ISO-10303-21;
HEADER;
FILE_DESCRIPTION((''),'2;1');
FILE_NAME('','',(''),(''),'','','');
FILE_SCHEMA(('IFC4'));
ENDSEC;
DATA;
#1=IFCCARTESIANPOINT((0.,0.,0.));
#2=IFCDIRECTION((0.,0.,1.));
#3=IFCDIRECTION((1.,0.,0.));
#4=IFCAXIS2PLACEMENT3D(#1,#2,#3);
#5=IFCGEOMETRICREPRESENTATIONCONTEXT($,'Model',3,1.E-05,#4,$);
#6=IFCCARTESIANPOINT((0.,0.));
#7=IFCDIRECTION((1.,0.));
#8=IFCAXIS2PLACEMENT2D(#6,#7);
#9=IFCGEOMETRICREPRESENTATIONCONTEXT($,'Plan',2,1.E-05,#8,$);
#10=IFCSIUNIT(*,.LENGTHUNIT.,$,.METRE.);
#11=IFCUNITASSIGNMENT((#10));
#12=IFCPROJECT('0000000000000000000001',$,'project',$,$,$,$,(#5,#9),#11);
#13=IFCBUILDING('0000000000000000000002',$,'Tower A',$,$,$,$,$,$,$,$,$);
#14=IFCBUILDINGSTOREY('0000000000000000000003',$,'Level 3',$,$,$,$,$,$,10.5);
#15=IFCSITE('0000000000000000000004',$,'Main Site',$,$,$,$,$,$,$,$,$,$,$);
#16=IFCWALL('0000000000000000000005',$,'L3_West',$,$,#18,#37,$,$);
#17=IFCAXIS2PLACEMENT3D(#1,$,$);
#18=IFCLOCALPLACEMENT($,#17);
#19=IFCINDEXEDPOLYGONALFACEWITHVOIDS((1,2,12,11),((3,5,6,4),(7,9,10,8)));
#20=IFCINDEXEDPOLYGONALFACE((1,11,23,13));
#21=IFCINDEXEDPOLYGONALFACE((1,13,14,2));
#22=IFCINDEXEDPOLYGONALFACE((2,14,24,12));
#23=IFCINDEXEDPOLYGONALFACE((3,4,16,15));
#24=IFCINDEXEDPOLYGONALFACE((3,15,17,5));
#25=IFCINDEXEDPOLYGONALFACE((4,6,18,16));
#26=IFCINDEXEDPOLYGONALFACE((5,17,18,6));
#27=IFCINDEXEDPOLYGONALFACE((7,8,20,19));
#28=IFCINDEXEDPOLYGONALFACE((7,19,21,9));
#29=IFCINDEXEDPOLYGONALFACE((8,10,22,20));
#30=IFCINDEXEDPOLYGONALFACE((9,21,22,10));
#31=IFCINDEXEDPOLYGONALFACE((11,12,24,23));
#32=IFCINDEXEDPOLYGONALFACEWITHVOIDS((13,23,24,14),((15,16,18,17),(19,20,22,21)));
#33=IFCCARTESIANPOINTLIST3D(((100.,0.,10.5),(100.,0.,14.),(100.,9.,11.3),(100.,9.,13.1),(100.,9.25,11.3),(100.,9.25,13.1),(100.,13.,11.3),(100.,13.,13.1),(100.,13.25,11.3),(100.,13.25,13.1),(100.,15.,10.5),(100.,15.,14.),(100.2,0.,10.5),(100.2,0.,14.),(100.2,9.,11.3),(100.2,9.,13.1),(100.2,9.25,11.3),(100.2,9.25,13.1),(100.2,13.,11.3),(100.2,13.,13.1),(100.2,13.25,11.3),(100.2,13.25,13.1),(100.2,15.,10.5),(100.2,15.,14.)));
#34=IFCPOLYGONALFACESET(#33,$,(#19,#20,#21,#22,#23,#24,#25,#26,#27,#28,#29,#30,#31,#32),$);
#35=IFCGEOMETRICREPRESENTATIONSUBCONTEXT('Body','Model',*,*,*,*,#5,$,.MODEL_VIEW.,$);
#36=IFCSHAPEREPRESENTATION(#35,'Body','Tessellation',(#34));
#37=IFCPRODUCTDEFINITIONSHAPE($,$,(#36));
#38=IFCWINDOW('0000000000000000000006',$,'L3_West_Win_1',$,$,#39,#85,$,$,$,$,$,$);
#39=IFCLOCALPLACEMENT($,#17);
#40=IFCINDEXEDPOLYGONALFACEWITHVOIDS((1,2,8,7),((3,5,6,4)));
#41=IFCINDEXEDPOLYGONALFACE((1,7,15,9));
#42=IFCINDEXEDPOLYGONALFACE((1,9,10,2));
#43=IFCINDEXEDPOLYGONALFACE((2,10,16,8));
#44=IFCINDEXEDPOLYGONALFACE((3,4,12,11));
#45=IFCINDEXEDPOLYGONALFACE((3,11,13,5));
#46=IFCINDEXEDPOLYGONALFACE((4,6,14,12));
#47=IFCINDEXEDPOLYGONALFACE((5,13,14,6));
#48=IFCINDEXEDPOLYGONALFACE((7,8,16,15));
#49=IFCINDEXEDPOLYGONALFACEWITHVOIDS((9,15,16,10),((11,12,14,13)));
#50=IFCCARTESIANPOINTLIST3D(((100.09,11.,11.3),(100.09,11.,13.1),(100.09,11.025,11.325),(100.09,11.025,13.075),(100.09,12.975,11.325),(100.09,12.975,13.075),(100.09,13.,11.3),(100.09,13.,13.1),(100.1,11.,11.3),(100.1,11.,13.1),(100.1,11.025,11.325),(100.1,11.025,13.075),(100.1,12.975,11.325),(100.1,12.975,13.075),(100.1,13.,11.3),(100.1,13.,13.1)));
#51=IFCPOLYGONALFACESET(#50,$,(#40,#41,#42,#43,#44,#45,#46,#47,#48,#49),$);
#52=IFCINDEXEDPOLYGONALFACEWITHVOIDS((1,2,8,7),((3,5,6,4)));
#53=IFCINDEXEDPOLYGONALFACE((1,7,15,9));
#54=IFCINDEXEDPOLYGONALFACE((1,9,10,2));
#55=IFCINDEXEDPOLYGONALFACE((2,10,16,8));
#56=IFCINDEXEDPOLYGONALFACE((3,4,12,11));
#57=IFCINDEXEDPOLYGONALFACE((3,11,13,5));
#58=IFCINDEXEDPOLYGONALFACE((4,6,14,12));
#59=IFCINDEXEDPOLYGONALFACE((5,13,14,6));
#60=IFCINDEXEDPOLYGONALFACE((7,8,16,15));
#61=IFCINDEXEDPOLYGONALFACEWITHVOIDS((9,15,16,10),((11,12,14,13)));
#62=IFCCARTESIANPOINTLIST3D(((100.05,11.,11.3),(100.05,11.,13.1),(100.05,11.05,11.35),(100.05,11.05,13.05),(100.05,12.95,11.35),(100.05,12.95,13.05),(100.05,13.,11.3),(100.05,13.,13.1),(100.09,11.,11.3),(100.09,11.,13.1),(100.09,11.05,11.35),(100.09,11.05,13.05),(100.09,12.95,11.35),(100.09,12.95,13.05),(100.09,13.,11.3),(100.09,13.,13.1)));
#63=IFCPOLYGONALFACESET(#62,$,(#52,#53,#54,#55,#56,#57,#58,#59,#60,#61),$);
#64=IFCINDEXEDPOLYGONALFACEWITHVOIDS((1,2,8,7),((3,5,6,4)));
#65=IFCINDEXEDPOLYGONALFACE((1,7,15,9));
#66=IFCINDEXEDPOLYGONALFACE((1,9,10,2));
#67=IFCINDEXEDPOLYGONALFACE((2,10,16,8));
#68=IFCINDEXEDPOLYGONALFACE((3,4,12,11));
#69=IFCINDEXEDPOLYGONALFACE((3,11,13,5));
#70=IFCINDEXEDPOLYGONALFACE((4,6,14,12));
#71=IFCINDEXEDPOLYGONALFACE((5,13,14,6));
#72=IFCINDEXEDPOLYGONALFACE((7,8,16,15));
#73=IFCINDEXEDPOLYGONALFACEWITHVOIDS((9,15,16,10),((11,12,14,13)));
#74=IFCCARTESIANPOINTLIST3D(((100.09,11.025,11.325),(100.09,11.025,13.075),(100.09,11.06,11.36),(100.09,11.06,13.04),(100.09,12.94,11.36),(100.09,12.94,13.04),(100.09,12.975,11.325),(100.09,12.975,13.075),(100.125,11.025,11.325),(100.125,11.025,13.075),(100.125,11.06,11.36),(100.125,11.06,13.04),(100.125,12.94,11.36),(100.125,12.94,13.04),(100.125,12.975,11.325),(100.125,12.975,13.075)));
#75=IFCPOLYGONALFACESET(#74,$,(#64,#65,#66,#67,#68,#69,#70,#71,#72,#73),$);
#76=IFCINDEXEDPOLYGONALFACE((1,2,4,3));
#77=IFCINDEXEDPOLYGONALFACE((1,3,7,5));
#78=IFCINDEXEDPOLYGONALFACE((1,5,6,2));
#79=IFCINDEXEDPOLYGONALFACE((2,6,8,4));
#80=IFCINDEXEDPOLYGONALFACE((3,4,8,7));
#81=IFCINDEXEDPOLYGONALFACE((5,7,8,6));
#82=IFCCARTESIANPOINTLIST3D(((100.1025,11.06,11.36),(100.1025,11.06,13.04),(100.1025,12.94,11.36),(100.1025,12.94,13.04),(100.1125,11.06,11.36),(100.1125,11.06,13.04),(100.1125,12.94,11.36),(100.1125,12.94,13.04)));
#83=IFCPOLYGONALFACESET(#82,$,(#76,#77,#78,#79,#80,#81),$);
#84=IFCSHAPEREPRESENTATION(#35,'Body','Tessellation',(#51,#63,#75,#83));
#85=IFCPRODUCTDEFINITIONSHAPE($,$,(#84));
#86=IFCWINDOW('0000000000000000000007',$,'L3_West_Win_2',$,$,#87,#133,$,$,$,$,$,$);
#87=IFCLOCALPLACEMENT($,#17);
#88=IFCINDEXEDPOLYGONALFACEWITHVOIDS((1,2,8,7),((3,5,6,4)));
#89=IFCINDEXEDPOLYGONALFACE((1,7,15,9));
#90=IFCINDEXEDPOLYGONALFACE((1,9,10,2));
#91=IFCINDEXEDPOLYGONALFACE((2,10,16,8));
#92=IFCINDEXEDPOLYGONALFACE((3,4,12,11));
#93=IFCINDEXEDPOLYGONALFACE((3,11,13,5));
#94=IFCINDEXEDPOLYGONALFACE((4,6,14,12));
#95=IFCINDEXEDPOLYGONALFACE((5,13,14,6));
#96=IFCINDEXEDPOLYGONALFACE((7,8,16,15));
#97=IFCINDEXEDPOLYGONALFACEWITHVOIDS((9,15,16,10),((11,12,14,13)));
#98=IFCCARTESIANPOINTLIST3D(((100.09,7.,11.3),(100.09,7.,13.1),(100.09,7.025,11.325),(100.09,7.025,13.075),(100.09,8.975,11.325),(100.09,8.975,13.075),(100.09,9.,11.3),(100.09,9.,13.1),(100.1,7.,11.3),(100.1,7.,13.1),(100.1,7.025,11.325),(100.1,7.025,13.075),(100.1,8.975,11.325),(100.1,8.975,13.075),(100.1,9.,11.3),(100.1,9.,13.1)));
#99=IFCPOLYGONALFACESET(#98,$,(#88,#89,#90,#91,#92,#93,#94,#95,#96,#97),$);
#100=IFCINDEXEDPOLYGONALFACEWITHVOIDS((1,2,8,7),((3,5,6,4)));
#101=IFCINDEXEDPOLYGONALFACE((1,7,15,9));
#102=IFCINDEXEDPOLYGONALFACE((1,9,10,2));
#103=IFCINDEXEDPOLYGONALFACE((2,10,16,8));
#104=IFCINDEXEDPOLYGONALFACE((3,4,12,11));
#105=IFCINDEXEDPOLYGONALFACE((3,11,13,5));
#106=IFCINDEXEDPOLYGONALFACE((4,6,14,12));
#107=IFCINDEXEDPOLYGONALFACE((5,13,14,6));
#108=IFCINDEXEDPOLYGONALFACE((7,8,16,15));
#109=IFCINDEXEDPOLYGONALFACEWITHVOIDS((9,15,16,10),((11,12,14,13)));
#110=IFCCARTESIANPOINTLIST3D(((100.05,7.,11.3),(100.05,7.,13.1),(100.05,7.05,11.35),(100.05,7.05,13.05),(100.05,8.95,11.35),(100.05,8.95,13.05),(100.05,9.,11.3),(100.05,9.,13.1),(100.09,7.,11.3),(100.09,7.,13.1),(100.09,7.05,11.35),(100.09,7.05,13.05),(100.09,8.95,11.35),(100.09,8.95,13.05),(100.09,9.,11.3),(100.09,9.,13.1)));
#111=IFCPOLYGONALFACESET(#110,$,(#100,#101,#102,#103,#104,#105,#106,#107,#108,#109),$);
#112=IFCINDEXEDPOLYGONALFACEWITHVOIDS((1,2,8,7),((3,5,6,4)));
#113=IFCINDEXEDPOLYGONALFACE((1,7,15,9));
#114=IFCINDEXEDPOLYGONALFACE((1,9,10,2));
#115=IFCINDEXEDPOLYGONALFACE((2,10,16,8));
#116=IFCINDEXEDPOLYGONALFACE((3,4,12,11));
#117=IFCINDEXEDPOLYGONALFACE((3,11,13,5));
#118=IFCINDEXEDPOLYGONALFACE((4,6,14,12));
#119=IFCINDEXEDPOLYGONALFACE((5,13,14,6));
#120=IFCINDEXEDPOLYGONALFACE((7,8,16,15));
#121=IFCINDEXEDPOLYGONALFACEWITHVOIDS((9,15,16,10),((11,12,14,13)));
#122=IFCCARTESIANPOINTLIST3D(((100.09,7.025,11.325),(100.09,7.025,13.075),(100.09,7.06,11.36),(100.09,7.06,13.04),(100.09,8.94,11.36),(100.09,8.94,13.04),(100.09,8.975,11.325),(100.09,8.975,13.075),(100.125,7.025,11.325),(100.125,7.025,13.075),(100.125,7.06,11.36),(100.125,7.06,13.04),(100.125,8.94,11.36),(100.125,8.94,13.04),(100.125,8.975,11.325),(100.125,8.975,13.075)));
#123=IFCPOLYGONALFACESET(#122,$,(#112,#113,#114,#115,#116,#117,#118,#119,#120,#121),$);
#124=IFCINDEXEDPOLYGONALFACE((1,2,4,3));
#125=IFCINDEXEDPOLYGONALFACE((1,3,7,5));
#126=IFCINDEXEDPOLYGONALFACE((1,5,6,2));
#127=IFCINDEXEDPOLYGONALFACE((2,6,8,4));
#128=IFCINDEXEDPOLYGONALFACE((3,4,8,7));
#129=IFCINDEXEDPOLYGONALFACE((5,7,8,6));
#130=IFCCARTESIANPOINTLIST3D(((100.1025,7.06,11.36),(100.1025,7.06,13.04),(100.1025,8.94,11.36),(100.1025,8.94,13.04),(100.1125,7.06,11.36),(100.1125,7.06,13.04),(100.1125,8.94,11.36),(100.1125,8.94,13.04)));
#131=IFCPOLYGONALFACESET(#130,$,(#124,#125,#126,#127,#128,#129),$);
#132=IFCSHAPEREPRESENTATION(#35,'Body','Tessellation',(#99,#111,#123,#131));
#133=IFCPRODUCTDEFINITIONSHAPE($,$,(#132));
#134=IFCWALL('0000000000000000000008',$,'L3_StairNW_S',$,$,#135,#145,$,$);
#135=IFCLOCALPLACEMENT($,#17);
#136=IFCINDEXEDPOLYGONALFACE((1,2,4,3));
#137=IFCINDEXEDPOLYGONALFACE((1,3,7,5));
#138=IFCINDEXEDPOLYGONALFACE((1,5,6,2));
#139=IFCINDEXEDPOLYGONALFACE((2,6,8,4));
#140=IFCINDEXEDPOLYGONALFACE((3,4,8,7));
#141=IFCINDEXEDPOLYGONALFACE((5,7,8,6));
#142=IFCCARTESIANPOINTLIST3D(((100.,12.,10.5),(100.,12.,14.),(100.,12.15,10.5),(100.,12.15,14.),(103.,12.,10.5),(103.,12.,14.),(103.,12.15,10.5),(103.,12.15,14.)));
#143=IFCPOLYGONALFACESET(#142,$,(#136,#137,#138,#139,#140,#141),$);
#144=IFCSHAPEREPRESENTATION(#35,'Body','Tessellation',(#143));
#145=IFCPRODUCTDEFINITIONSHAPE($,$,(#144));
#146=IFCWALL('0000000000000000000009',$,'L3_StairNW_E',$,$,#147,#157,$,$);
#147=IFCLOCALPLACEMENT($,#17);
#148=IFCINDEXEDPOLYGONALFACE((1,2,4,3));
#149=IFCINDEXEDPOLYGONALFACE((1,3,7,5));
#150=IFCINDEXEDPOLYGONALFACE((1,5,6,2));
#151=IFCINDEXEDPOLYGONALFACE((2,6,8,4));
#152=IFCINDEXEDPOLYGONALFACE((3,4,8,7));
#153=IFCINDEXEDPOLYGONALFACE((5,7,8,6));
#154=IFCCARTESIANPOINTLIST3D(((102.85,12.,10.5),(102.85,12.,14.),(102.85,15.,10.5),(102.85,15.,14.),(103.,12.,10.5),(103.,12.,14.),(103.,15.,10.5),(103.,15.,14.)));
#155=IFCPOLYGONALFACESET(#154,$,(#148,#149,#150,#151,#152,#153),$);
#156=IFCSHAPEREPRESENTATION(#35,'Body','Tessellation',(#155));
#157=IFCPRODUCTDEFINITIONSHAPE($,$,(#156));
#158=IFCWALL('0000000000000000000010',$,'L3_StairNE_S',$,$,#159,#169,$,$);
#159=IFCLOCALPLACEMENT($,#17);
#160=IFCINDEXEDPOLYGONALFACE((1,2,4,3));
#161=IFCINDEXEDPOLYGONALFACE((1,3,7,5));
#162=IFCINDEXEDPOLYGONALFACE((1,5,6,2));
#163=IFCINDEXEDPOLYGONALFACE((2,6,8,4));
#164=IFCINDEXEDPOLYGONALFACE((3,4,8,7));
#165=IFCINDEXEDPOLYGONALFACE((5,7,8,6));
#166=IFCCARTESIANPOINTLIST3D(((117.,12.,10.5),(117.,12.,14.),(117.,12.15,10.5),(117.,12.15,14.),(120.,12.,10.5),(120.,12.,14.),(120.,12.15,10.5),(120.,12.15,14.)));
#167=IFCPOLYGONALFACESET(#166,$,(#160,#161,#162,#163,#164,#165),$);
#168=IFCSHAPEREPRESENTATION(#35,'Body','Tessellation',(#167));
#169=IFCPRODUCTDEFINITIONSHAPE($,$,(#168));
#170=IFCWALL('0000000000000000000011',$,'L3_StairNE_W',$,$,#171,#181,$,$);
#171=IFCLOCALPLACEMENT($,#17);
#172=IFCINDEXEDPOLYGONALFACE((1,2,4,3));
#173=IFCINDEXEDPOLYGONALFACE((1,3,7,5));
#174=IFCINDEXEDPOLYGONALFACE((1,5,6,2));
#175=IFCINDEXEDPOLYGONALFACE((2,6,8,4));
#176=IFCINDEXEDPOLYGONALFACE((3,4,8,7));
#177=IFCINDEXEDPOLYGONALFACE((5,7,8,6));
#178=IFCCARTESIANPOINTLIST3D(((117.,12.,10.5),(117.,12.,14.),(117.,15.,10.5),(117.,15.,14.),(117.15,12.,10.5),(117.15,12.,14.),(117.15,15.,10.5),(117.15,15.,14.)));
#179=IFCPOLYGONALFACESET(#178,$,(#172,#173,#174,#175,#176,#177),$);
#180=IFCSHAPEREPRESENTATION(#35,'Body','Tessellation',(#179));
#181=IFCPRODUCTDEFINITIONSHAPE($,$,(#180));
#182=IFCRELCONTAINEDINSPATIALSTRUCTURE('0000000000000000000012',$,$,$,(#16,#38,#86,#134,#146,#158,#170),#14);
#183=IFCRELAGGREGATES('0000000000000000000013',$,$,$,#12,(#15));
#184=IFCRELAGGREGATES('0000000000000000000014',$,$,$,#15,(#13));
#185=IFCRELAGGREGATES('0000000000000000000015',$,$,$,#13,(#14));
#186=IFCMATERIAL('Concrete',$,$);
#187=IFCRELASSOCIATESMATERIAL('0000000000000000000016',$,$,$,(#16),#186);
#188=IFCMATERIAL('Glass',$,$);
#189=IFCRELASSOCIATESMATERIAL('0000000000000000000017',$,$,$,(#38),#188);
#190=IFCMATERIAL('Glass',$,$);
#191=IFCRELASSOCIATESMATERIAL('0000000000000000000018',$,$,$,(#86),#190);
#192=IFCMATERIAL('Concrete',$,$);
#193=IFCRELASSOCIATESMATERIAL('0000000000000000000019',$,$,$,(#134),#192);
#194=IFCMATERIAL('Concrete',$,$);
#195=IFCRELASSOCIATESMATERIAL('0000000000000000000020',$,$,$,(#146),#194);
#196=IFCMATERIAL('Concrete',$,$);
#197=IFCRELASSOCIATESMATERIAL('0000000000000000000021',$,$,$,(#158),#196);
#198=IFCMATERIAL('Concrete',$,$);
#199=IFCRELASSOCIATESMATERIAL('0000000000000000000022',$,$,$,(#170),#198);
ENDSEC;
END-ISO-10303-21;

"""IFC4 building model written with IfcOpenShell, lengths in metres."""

from ifc_helpers import new_model, si_unit, frame, origin_with_axes, origin_2d_with_axis, place, context, subcontext, project, spatial, line, indexed_curve, outline, extrude, material, element, fill, save


model = new_model("IFC4")

# Units and contexts
model_context = context("Model", 3, precision=1e-05, world=origin_with_axes())
plan_context = context("Plan", 2, precision=1e-05, world=origin_2d_with_axis())
body_context = subcontext(model_context, "Body", "Model", "MODEL_VIEW")
ifc_project = project(units=[si_unit("LENGTHUNIT", "METRE")], contexts=[model_context, plan_context])

# Site, building, storey
site = spatial("IfcSite", under=ifc_project, Name="Main Site")
building = spatial("IfcBuilding", under=site, Name="Tower A")
storey = spatial("IfcBuildingStorey", under=building, Name="Level 3", Elevation=10.5)

# Wall, openings, windows
ifc_material_1 = material(Name="Concrete")
wall_1_placement = place(None, frame((100.0, 15.0, 10.5), z_axis=(0.0, 0.0, 1.0), x_axis=(0.0, -1.0, 0.0)))
wall_1 = element("IfcWall", 1, at=wall_1_placement, inside=storey, material=ifc_material_1, Name="L3_West", context=body_context, shape_type="SweptSolid", body=[
    extrude(outline(indexed_curve([(0.0, 0.0), (0.0, 0.2), (15.0, 0.2), (15.0, 0.0), (0.0, 0.0)], self_intersect=False)), origin_with_axes(), (0.0, 0.0, 1.0), 3.5),
])
opening_1_placement = place(wall_1_placement, frame((2.0, 0.0, 0.8), z_axis=(0.0, 0.0, 1.0), x_axis=(0.0, 1.0, 0.0)))
opening_1 = element("IfcOpeningElement", 2, at=opening_1_placement, cuts=wall_1, context=body_context, shape_type="SweptSolid", body=[
    extrude(outline(indexed_curve([(0.0, 0.0), (0.0, 0.25), (2.0, 0.25), (2.0, 0.0), (0.0, 0.0)], self_intersect=False)), origin_with_axes(), (0.0, 0.0, 1.0), 1.8),
])
opening_2_placement = place(wall_1_placement, frame((6.0, 0.0, 0.8), z_axis=(0.0, 0.0, 1.0), x_axis=(0.0, 1.0, 0.0)))
opening_2 = element("IfcOpeningElement", 3, at=opening_2_placement, cuts=wall_1, context=body_context, shape_type="SweptSolid", body=[
    extrude(outline(indexed_curve([(0.0, 0.0), (0.0, 0.25), (2.0, 0.25), (2.0, 0.0), (0.0, 0.0)], self_intersect=False)), origin_with_axes(), (0.0, 0.0, 1.0), 1.8),
])
ifc_material_2 = material(Name="Glass")
window_1_placement = place(None, frame((100.0, 13.0, 11.3), z_axis=(0.0, 0.0, 1.0), x_axis=(0.0, -1.0, 0.0)))
window_1 = element("IfcWindow", 4, at=window_1_placement, inside=storey, material=ifc_material_2, Name="L3_West_Win_1", context=body_context, shape_type="SweptSolid", body=[
    extrude(outline(indexed_curve([(0.0, 0.0), (2.0, 0.0), (2.0, 1.8), (0.0, 1.8)], segments=[line(1, 2, 3, 4, 1)]), holes=[indexed_curve([(0.025, 0.025), (1.975, 0.025), (1.975, 1.775), (0.025, 1.775)], segments=[line(1, 2, 3, 4, 1)])]), frame((0.0, 0.09, 0.0), z_axis=(0.0, -1.0, 0.0), x_axis=(1.0, 0.0, 0.0)), (0.0, 0.0, -1.0), 0.01),
    extrude(outline(indexed_curve([(0.0, 0.0), (2.0, 0.0), (2.0, 1.8), (0.0, 1.8)], segments=[line(1, 2, 3, 4, 1)]), holes=[indexed_curve([(0.05, 0.05), (1.95, 0.05), (1.95, 1.75), (0.05, 1.75)], segments=[line(1, 2, 3, 4, 1)])]), frame((0.0, 0.05, 0.0), z_axis=(0.0, -1.0, 0.0), x_axis=(1.0, 0.0, 0.0)), (0.0, 0.0, -1.0), 0.04),
    extrude(outline(indexed_curve([(0.0, 0.0), (1.95, 0.0), (1.95, 1.75), (0.0, 1.75)], segments=[line(1, 2, 3, 4, 1)]), holes=[indexed_curve([(0.035, 0.035), (1.915, 0.035), (1.915, 1.715), (0.035, 1.715)], segments=[line(1, 2, 3, 4, 1)])]), frame((0.025, 0.09, 0.025), z_axis=(0.0, -1.0, 0.0), x_axis=(1.0, 0.0, 0.0)), (0.0, 0.0, -1.0), 0.035),
    extrude(outline(indexed_curve([(0.035, 0.035), (1.915, 0.035), (1.915, 1.715), (0.035, 1.715)], segments=[line(1, 2, 3, 4, 1)])), frame((0.025, 0.1025, 0.025), z_axis=(0.0, -1.0, 0.0), x_axis=(1.0, 0.0, 0.0)), (0.0, 0.0, -1.0), 0.01),
])
fill(opening_1, window_1)
ifc_material_3 = material(Name="Glass")
window_2_placement = place(None, frame((100.0, 9.0, 11.3), z_axis=(0.0, 0.0, 1.0), x_axis=(0.0, -1.0, 0.0)))
window_2 = element("IfcWindow", 5, at=window_2_placement, inside=storey, material=ifc_material_3, Name="L3_West_Win_2", context=body_context, shape_type="SweptSolid", body=[
    extrude(outline(indexed_curve([(0.0, 0.0), (2.0, 0.0), (2.0, 1.8), (0.0, 1.8)], segments=[line(1, 2, 3, 4, 1)]), holes=[indexed_curve([(0.025, 0.025), (1.975, 0.025), (1.975, 1.775), (0.025, 1.775)], segments=[line(1, 2, 3, 4, 1)])]), frame((0.0, 0.09, 0.0), z_axis=(0.0, -1.0, 0.0), x_axis=(1.0, 0.0, 0.0)), (0.0, 0.0, -1.0), 0.01),
    extrude(outline(indexed_curve([(0.0, 0.0), (2.0, 0.0), (2.0, 1.8), (0.0, 1.8)], segments=[line(1, 2, 3, 4, 1)]), holes=[indexed_curve([(0.05, 0.05), (1.95, 0.05), (1.95, 1.75), (0.05, 1.75)], segments=[line(1, 2, 3, 4, 1)])]), frame((0.0, 0.05, 0.0), z_axis=(0.0, -1.0, 0.0), x_axis=(1.0, 0.0, 0.0)), (0.0, 0.0, -1.0), 0.04),
    extrude(outline(indexed_curve([(0.0, 0.0), (1.95, 0.0), (1.95, 1.75), (0.0, 1.75)], segments=[line(1, 2, 3, 4, 1)]), holes=[indexed_curve([(0.035, 0.035), (1.915, 0.035), (1.915, 1.715), (0.035, 1.715)], segments=[line(1, 2, 3, 4, 1)])]), frame((0.025, 0.09, 0.025), z_axis=(0.0, -1.0, 0.0), x_axis=(1.0, 0.0, 0.0)), (0.0, 0.0, -1.0), 0.035),
    extrude(outline(indexed_curve([(0.035, 0.035), (1.915, 0.035), (1.915, 1.715), (0.035, 1.715)], segments=[line(1, 2, 3, 4, 1)])), frame((0.025, 0.1025, 0.025), z_axis=(0.0, -1.0, 0.0), x_axis=(1.0, 0.0, 0.0)), (0.0, 0.0, -1.0), 0.01),
])
fill(opening_2, window_2)

# Walls
ifc_material_4 = material(Name="Concrete")
wall_2_placement = place(None, frame((100.0, 12.0, 10.5), z_axis=(0.0, 0.0, 1.0), x_axis=(1.0, 0.0, 0.0)))
element("IfcWall", 6, at=wall_2_placement, inside=storey, material=ifc_material_4, Name="L3_StairNW_S", context=body_context, shape_type="SweptSolid", body=[
    extrude(outline(indexed_curve([(0.0, 0.0), (0.0, 0.15), (3.0, 0.15), (3.0, 0.0), (0.0, 0.0)], self_intersect=False)), origin_with_axes(), (0.0, 0.0, 1.0), 3.5),
])
ifc_material_5 = material(Name="Concrete")
wall_3_placement = place(None, frame((103.0, 12.0, 10.5), z_axis=(0.0, 0.0, 1.0), x_axis=(0.0, 1.0, 0.0)))
element("IfcWall", 7, at=wall_3_placement, inside=storey, material=ifc_material_5, Name="L3_StairNW_E", context=body_context, shape_type="SweptSolid", body=[
    extrude(outline(indexed_curve([(0.0, 0.0), (0.0, 0.15), (3.0, 0.15), (3.0, 0.0), (0.0, 0.0)], self_intersect=False)), origin_with_axes(), (0.0, 0.0, 1.0), 3.5),
])
ifc_material_6 = material(Name="Concrete")
wall_4_placement = place(None, frame((117.0, 12.0, 10.5), z_axis=(0.0, 0.0, 1.0), x_axis=(1.0, 0.0, 0.0)))
element("IfcWall", 8, at=wall_4_placement, inside=storey, material=ifc_material_6, Name="L3_StairNE_S", context=body_context, shape_type="SweptSolid", body=[
    extrude(outline(indexed_curve([(0.0, 0.0), (0.0, 0.15), (3.0, 0.15), (3.0, 0.0), (0.0, 0.0)], self_intersect=False)), origin_with_axes(), (0.0, 0.0, 1.0), 3.5),
])
ifc_material_7 = material(Name="Concrete")
wall_5_placement = place(None, frame((117.0, 15.0, 10.5), z_axis=(0.0, 0.0, 1.0), x_axis=(0.0, -1.0, 0.0)))
element("IfcWall", 9, at=wall_5_placement, inside=storey, material=ifc_material_7, Name="L3_StairNE_W", context=body_context, shape_type="SweptSolid", body=[
    extrude(outline(indexed_curve([(0.0, 0.0), (0.0, 0.15), (3.0, 0.15), (3.0, 0.0), (0.0, 0.0)], self_intersect=False)), origin_with_axes(), (0.0, 0.0, 1.0), 3.5),
])

save(model, "model.ifc")
